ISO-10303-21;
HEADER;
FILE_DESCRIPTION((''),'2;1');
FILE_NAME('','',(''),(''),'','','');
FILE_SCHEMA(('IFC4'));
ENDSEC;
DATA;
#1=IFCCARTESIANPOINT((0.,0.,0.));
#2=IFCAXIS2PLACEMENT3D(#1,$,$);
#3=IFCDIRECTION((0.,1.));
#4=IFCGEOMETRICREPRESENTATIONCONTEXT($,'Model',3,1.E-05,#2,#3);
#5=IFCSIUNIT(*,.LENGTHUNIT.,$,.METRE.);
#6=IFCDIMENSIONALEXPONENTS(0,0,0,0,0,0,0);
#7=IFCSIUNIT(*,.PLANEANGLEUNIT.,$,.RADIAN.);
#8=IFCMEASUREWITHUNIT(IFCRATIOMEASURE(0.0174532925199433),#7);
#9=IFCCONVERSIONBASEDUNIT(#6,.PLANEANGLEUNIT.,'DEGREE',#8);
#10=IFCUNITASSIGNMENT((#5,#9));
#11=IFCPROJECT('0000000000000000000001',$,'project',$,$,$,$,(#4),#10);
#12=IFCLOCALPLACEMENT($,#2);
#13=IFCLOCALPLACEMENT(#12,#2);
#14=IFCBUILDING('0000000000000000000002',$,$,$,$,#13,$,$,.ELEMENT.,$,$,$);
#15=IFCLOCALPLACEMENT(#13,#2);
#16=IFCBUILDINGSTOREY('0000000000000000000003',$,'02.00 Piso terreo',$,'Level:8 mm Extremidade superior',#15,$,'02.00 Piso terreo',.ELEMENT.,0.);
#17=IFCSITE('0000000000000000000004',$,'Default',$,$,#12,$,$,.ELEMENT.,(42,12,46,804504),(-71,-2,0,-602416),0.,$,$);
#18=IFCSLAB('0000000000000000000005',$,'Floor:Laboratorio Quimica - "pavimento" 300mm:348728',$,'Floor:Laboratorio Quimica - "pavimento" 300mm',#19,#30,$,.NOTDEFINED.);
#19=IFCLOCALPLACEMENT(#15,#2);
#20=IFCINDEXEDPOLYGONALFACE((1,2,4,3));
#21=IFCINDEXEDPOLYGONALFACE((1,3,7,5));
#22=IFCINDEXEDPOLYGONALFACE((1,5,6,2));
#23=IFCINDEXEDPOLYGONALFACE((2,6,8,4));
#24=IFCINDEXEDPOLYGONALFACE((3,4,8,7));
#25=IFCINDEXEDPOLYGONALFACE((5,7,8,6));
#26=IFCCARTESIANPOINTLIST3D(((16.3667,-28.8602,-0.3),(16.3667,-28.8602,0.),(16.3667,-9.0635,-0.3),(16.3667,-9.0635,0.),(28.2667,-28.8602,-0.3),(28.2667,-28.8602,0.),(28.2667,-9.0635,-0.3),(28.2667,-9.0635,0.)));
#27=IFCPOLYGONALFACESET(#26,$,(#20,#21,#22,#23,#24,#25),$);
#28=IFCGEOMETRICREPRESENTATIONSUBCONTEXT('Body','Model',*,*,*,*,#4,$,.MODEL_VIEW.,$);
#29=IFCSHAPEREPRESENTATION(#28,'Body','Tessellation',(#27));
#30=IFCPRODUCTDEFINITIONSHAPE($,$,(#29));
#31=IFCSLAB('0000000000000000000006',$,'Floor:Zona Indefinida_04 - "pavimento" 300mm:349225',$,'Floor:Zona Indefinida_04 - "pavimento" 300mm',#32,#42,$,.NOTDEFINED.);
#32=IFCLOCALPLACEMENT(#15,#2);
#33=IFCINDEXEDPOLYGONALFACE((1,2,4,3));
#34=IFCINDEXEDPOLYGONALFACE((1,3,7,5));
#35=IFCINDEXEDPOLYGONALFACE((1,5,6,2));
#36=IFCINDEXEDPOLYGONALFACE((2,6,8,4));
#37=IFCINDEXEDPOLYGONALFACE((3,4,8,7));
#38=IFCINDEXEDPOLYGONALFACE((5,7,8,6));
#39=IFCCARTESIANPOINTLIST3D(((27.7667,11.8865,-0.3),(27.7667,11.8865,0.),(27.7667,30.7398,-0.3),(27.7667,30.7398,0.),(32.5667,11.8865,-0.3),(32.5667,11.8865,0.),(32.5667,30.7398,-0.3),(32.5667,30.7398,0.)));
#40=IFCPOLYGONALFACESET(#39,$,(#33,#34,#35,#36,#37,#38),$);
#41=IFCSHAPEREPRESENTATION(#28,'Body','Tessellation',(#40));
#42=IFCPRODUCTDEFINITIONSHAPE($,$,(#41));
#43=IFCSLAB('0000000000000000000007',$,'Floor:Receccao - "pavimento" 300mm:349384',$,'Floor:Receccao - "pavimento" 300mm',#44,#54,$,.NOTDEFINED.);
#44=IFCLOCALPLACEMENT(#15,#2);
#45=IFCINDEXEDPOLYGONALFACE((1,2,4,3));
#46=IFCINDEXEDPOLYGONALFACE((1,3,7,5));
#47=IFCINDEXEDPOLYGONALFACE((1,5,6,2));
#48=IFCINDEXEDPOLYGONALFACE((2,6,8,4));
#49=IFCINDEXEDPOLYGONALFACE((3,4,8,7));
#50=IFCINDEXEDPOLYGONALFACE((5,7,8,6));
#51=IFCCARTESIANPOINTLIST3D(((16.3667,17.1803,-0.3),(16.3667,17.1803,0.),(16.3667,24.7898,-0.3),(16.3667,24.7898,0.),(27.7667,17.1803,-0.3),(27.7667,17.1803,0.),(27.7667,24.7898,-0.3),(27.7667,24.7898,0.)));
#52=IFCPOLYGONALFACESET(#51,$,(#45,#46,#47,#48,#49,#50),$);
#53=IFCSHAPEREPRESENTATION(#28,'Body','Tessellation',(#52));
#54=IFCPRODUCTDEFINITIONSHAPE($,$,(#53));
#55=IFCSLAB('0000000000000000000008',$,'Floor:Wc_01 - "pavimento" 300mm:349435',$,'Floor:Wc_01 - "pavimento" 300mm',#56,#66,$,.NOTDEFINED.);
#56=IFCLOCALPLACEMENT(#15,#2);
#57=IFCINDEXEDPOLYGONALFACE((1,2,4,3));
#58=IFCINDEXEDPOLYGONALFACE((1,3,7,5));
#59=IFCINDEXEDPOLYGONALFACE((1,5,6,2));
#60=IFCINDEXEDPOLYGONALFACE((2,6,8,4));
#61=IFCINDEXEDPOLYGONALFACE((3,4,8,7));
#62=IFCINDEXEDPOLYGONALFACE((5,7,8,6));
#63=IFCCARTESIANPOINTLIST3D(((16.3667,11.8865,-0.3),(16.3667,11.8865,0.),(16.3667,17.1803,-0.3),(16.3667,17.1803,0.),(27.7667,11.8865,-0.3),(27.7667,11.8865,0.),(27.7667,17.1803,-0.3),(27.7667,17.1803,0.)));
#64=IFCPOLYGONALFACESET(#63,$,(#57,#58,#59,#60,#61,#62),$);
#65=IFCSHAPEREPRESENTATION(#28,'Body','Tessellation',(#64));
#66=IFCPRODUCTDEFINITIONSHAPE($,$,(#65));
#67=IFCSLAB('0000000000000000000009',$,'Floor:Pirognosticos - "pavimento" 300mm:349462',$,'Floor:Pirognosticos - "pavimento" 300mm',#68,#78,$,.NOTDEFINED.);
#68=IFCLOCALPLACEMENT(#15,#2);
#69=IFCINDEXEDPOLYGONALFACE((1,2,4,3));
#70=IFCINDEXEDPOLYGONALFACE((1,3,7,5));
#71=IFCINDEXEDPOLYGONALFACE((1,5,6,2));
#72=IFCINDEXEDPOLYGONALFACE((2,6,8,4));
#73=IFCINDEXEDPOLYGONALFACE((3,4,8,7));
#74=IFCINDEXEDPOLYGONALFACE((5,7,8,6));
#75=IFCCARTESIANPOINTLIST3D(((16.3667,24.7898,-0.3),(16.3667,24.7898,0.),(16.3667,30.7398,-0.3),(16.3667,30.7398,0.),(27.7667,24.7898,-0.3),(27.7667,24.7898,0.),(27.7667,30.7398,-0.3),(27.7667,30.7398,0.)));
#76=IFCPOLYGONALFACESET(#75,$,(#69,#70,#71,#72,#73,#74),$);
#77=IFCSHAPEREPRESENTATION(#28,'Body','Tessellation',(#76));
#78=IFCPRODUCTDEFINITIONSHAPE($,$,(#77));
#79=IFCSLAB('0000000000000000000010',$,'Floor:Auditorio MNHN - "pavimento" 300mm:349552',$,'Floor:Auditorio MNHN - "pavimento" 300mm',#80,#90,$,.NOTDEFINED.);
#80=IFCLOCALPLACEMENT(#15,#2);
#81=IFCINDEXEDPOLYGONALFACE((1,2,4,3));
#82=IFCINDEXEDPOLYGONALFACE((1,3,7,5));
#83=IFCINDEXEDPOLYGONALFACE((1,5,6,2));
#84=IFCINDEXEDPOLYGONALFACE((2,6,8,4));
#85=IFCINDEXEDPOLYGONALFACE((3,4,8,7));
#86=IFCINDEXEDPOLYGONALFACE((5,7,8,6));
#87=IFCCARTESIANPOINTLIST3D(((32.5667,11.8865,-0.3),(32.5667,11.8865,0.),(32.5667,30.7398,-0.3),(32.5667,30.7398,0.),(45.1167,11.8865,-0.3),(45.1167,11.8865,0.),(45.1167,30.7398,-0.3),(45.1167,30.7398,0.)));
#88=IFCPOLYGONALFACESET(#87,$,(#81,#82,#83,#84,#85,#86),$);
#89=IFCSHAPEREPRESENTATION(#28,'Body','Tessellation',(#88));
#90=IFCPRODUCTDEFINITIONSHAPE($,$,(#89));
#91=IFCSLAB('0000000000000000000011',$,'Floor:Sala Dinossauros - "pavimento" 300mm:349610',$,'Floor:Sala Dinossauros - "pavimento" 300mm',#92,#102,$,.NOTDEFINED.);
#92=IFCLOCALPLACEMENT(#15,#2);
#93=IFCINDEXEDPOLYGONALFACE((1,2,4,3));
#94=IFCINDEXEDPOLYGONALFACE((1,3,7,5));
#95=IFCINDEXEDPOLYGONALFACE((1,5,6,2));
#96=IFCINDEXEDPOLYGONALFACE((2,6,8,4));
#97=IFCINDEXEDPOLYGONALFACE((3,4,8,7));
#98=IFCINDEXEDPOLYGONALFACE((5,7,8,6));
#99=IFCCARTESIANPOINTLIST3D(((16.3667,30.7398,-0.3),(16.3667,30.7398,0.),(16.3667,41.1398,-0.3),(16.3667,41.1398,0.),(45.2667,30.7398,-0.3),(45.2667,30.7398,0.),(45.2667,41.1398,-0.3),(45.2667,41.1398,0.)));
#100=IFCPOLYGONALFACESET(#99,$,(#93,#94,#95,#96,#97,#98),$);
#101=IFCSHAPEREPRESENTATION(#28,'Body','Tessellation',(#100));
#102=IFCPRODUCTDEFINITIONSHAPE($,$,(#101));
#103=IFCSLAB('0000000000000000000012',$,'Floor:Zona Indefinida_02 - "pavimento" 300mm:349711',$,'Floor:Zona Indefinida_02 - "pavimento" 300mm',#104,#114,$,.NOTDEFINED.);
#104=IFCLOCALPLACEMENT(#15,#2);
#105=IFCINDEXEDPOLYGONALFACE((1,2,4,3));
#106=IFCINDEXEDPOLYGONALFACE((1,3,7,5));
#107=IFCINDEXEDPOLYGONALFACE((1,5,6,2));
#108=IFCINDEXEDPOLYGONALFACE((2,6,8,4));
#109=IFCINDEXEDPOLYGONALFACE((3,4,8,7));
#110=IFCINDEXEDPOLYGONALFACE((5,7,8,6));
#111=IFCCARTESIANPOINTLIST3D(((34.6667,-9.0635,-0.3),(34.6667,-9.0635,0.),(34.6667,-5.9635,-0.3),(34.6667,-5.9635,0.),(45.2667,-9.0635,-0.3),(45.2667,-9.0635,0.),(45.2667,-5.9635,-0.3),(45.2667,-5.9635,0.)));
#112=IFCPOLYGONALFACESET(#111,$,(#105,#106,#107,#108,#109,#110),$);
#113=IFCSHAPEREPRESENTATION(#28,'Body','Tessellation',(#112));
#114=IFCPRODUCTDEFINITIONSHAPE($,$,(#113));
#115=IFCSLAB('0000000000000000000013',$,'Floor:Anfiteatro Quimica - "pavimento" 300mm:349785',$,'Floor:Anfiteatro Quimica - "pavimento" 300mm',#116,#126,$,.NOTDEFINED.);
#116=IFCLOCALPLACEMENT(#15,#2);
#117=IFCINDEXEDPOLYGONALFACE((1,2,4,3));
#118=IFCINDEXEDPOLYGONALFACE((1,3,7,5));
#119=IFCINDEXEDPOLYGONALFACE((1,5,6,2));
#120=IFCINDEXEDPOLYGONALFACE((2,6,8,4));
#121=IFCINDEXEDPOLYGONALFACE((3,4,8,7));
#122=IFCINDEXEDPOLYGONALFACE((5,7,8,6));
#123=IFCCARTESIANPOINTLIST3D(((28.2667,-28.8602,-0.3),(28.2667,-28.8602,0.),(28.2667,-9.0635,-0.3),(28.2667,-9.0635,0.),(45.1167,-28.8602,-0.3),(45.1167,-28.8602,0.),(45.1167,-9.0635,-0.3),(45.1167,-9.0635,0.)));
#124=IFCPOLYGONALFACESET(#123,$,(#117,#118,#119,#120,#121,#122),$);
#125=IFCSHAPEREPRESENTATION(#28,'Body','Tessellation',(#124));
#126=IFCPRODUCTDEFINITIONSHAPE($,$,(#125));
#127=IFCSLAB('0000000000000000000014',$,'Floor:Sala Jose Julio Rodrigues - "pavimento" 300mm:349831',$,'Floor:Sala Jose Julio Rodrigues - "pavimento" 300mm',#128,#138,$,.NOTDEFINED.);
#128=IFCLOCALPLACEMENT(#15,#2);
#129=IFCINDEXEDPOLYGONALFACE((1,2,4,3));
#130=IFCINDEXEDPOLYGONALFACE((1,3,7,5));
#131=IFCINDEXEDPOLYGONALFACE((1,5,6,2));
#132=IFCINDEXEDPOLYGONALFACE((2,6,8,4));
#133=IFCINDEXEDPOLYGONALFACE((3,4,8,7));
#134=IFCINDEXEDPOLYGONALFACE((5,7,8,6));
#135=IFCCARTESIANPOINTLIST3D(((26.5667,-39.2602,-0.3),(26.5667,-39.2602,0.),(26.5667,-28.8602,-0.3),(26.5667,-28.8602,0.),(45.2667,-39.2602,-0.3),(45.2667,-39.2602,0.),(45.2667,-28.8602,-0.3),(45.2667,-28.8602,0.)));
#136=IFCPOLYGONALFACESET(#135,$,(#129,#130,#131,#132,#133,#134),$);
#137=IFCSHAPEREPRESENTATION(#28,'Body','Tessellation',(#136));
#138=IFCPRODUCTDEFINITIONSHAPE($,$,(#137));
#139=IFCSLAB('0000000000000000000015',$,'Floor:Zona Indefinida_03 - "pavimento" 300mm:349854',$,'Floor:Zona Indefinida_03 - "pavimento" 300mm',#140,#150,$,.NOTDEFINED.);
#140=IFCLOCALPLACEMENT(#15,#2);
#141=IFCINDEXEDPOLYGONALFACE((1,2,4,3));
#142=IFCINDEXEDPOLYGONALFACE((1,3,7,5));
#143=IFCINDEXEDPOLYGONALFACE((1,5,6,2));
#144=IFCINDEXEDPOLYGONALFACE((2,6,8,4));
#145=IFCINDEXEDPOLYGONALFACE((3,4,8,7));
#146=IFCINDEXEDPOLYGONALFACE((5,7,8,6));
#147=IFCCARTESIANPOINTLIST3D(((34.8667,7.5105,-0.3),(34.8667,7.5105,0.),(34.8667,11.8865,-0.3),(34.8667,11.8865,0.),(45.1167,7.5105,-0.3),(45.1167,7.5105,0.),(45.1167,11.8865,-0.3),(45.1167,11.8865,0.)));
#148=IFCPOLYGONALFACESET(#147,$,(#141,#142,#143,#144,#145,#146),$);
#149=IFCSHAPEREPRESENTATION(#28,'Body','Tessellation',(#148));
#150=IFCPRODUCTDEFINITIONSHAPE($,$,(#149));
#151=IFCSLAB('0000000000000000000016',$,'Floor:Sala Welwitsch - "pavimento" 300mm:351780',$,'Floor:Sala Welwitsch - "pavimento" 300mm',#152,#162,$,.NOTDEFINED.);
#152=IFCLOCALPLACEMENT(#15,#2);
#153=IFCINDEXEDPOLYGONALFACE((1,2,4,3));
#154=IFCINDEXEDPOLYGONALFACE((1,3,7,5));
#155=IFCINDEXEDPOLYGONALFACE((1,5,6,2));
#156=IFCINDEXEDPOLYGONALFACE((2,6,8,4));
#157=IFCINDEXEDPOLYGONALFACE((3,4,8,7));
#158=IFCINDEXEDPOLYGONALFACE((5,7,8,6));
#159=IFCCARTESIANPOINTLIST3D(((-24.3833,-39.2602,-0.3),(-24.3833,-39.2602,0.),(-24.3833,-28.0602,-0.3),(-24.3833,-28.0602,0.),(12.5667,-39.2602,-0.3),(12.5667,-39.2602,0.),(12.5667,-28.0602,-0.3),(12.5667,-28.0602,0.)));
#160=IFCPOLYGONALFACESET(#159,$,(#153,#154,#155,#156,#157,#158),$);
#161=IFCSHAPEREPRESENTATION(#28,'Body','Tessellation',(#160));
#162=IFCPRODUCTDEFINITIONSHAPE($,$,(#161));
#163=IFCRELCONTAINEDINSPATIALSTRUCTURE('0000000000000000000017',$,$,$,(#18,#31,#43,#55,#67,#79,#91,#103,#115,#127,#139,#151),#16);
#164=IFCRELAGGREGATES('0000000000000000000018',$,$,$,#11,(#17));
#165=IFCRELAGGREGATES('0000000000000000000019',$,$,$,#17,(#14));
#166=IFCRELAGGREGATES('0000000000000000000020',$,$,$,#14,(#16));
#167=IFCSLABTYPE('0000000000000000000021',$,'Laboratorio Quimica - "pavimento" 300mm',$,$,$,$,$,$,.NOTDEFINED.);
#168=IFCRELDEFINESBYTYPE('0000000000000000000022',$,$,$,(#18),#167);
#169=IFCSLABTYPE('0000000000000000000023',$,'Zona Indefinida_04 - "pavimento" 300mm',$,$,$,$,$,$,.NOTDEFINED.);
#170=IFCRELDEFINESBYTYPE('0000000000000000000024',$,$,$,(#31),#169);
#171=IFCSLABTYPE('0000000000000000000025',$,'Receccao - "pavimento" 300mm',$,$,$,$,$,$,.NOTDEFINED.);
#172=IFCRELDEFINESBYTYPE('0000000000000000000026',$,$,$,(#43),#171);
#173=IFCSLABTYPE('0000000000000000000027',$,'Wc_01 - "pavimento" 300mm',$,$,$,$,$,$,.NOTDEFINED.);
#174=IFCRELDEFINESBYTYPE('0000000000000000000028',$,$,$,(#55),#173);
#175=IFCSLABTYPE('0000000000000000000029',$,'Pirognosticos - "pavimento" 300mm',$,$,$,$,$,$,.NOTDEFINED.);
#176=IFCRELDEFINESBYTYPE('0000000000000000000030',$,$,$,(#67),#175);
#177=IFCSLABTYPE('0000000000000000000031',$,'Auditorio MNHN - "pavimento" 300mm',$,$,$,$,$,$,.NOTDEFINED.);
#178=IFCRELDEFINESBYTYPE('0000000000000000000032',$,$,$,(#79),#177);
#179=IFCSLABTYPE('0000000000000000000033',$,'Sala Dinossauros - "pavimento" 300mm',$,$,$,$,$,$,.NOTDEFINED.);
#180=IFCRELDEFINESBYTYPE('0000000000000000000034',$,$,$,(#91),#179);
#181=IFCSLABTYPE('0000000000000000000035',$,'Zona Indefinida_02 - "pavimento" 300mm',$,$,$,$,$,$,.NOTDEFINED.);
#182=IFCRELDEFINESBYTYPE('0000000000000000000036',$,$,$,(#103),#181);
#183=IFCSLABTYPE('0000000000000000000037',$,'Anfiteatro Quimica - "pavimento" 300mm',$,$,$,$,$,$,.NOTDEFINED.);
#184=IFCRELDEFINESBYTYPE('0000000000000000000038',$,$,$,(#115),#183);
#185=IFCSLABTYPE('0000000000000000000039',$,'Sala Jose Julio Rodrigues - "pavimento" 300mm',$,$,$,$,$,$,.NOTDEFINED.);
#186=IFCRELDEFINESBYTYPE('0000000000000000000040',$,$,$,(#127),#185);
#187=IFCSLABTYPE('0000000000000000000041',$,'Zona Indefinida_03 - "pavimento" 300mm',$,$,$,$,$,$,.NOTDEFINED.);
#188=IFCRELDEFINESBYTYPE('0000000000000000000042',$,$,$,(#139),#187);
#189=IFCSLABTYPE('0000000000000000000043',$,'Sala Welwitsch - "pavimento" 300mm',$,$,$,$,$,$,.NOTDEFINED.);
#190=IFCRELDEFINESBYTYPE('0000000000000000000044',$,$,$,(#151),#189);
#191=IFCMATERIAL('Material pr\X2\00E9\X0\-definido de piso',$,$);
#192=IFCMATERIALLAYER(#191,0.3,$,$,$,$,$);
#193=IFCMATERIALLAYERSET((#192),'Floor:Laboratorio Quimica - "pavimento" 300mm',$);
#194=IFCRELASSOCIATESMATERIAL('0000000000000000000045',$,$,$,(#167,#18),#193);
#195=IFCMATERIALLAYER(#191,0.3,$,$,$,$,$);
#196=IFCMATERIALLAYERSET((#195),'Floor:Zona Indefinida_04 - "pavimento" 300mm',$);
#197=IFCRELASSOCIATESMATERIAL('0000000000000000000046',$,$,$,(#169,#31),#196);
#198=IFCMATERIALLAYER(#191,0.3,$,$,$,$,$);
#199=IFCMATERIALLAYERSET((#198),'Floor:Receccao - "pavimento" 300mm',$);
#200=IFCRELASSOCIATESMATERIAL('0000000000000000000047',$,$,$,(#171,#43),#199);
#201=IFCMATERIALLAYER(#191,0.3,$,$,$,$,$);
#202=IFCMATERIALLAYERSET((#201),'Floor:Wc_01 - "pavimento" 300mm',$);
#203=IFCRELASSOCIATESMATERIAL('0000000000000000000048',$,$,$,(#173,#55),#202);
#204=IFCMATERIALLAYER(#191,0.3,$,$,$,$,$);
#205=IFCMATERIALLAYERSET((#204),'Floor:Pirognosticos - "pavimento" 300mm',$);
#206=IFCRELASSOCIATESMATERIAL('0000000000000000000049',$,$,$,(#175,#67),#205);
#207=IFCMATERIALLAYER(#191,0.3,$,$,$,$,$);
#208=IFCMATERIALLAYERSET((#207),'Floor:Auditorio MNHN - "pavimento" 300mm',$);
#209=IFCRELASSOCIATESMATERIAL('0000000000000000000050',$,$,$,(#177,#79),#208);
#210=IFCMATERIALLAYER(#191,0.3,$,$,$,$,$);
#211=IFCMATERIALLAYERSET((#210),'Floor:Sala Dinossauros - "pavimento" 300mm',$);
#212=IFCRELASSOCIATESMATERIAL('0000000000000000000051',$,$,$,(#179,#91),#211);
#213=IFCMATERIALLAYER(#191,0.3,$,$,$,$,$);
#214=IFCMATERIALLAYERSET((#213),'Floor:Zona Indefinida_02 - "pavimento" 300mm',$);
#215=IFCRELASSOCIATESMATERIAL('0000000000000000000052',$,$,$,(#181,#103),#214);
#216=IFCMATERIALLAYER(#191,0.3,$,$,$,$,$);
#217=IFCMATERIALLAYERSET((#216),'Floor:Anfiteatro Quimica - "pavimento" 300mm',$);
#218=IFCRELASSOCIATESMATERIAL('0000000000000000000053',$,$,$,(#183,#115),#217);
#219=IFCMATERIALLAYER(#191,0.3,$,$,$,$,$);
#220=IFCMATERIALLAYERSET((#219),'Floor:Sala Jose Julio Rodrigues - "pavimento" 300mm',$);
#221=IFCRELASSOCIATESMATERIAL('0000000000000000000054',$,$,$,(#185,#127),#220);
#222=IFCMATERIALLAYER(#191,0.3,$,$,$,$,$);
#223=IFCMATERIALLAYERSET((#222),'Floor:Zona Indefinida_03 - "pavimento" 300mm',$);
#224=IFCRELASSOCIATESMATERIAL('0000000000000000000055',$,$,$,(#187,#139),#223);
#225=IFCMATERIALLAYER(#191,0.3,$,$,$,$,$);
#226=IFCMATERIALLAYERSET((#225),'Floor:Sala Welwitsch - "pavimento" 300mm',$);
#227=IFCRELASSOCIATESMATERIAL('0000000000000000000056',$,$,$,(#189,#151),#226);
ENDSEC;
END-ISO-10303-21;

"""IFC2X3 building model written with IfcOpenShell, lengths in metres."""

from ifc_helpers import new_model, entity, si_unit, converted_unit, direction, frame, frame_2d, origin, origin_2d_with_axis, place, context, subcontext, project, spatial, rectangle, extrude, material, layer, layer_set, layer_usage, type_object, element, save


model = new_model("IFC2X3")

# Units and contexts
model_context = context("Model", 3, precision=1e-05, world=origin(), true_north=direction((0.0, 1.0)))
body_context = subcontext(model_context, "Body", "Model", "MODEL_VIEW")
ifc_project = project(units=[si_unit("LENGTHUNIT", "METRE"), converted_unit("PLANEANGLEUNIT", "DEGREE", entity("IfcRatioMeasure", 0.0174532925199433), si_unit("PLANEANGLEUNIT", "RADIAN"), dimensions=[0, 0, 0, 0, 0, 0, 0])], contexts=[model_context])

# Site, building, storey
site_placement = place(None, origin())
site = spatial("IfcSite", under=ifc_project, at=site_placement, Name="Default", CompositionType="ELEMENT", RefLatitude=(42, 12, 46, 804504), RefLongitude=(-71, -2, 0, -602416), RefElevation=0.0)
building_placement = place(site_placement, origin())
building = spatial("IfcBuilding", under=site, at=building_placement, CompositionType="ELEMENT")
storey_placement = place(building_placement, origin())
storey = spatial("IfcBuildingStorey", under=building, at=storey_placement, Name="02.00 Piso terreo", ObjectType="Level:8 mm Extremidade superior", LongName="02.00 Piso terreo", CompositionType="ELEMENT", Elevation=0.0)

# Slabs
ifc_material = material(Name="Material pré-definido de piso")
ifc_layer_1 = layer(ifc_material, 0.3)
ifc_layer_set_1 = layer_set([ifc_layer_1], Name="Floor:Laboratorio Quimica - \"pavimento\" 300mm")
ifc_layer_usage_1 = layer_usage(ifc_layer_set_1, "AXIS3", "POSITIVE", 0.0)
slab_type_1 = type_object("IfcSlabType", Name="Laboratorio Quimica - \"pavimento\" 300mm", PredefinedType="NOTDEFINED", material=ifc_layer_set_1)
slab_1_placement = place(storey_placement, origin())
element("IfcSlab", 1, at=slab_1_placement, inside=storey, type_object=slab_type_1, material=ifc_layer_usage_1, Name="Floor:Laboratorio Quimica - \"pavimento\" 300mm:348728", ObjectType="Floor:Laboratorio Quimica - \"pavimento\" 300mm", PredefinedType="NOTDEFINED", context=body_context, shape_type="SweptSolid", body=[
    extrude(rectangle(XDim=19.7967, YDim=11.9, at=frame_2d((0.0, 0.0), x_axis=(1.0, 0.0))), frame((22.3167, -18.9618, 0.0), z_axis=(0.0, 0.0, -1.0), x_axis=(0.0, 1.0, 0.0)), (0.0, 0.0, 1.0), 0.3),
])
ifc_layer_2 = layer(ifc_material, 0.3)
ifc_layer_set_2 = layer_set([ifc_layer_2], Name="Floor:Zona Indefinida_04 - \"pavimento\" 300mm")
ifc_layer_usage_2 = layer_usage(ifc_layer_set_2, "AXIS3", "POSITIVE", 0.0)
slab_type_2 = type_object("IfcSlabType", Name="Zona Indefinida_04 - \"pavimento\" 300mm", PredefinedType="NOTDEFINED", material=ifc_layer_set_2)
slab_2_placement = place(storey_placement, origin())
element("IfcSlab", 2, at=slab_2_placement, inside=storey, type_object=slab_type_2, material=ifc_layer_usage_2, Name="Floor:Zona Indefinida_04 - \"pavimento\" 300mm:349225", ObjectType="Floor:Zona Indefinida_04 - \"pavimento\" 300mm", PredefinedType="NOTDEFINED", context=body_context, shape_type="SweptSolid", body=[
    extrude(rectangle(XDim=18.8533, YDim=4.8, at=frame_2d((0.0, 0.0), x_axis=(1.0, 0.0))), frame((30.1667, 21.3132, 0.0), z_axis=(0.0, 0.0, -1.0), x_axis=(0.0, 1.0, 0.0)), (0.0, 0.0, 1.0), 0.3),
])
ifc_layer_3 = layer(ifc_material, 0.3)
ifc_layer_set_3 = layer_set([ifc_layer_3], Name="Floor:Receccao - \"pavimento\" 300mm")
ifc_layer_usage_3 = layer_usage(ifc_layer_set_3, "AXIS3", "POSITIVE", 0.0)
slab_type_3 = type_object("IfcSlabType", Name="Receccao - \"pavimento\" 300mm", PredefinedType="NOTDEFINED", material=ifc_layer_set_3)
slab_3_placement = place(storey_placement, origin())
element("IfcSlab", 3, at=slab_3_placement, inside=storey, type_object=slab_type_3, material=ifc_layer_usage_3, Name="Floor:Receccao - \"pavimento\" 300mm:349384", ObjectType="Floor:Receccao - \"pavimento\" 300mm", PredefinedType="NOTDEFINED", context=body_context, shape_type="SweptSolid", body=[
    extrude(rectangle(XDim=7.6095, YDim=11.4, at=frame_2d((0.0, 0.0), x_axis=(1.0, 0.0))), frame((22.0667, 20.9851, 0.0), z_axis=(0.0, 0.0, -1.0), x_axis=(0.0, 1.0, 0.0)), (0.0, 0.0, 1.0), 0.3),
])
ifc_layer_4 = layer(ifc_material, 0.3)
ifc_layer_set_4 = layer_set([ifc_layer_4], Name="Floor:Wc_01 - \"pavimento\" 300mm")
ifc_layer_usage_4 = layer_usage(ifc_layer_set_4, "AXIS3", "POSITIVE", 0.0)
slab_type_4 = type_object("IfcSlabType", Name="Wc_01 - \"pavimento\" 300mm", PredefinedType="NOTDEFINED", material=ifc_layer_set_4)
slab_4_placement = place(storey_placement, origin())
element("IfcSlab", 4, at=slab_4_placement, inside=storey, type_object=slab_type_4, material=ifc_layer_usage_4, Name="Floor:Wc_01 - \"pavimento\" 300mm:349435", ObjectType="Floor:Wc_01 - \"pavimento\" 300mm", PredefinedType="NOTDEFINED", context=body_context, shape_type="SweptSolid", body=[
    extrude(rectangle(XDim=5.2938, YDim=11.4, at=frame_2d((0.0, 0.0), x_axis=(1.0, 0.0))), frame((22.0667, 14.5334, 0.0), z_axis=(0.0, 0.0, -1.0), x_axis=(0.0, 1.0, 0.0)), (0.0, 0.0, 1.0), 0.3),
])
ifc_layer_5 = layer(ifc_material, 0.3)
ifc_layer_set_5 = layer_set([ifc_layer_5], Name="Floor:Pirognosticos - \"pavimento\" 300mm")
ifc_layer_usage_5 = layer_usage(ifc_layer_set_5, "AXIS3", "POSITIVE", 0.0)
slab_type_5 = type_object("IfcSlabType", Name="Pirognosticos - \"pavimento\" 300mm", PredefinedType="NOTDEFINED", material=ifc_layer_set_5)
slab_5_placement = place(storey_placement, origin())
element("IfcSlab", 5, at=slab_5_placement, inside=storey, type_object=slab_type_5, material=ifc_layer_usage_5, Name="Floor:Pirognosticos - \"pavimento\" 300mm:349462", ObjectType="Floor:Pirognosticos - \"pavimento\" 300mm", PredefinedType="NOTDEFINED", context=body_context, shape_type="SweptSolid", body=[
    extrude(rectangle(XDim=5.95, YDim=11.4, at=origin_2d_with_axis()), frame((22.0667, 27.7648, 0.0), z_axis=(0.0, 0.0, -1.0), x_axis=(0.0, 1.0, 0.0)), (0.0, 0.0, 1.0), 0.3),
])
ifc_layer_6 = layer(ifc_material, 0.3)
ifc_layer_set_6 = layer_set([ifc_layer_6], Name="Floor:Auditorio MNHN - \"pavimento\" 300mm")
ifc_layer_usage_6 = layer_usage(ifc_layer_set_6, "AXIS3", "POSITIVE", 0.0)
slab_type_6 = type_object("IfcSlabType", Name="Auditorio MNHN - \"pavimento\" 300mm", PredefinedType="NOTDEFINED", material=ifc_layer_set_6)
slab_6_placement = place(storey_placement, origin())
element("IfcSlab", 6, at=slab_6_placement, inside=storey, type_object=slab_type_6, material=ifc_layer_usage_6, Name="Floor:Auditorio MNHN - \"pavimento\" 300mm:349552", ObjectType="Floor:Auditorio MNHN - \"pavimento\" 300mm", PredefinedType="NOTDEFINED", context=body_context, shape_type="SweptSolid", body=[
    extrude(rectangle(XDim=18.8533, YDim=12.55, at=frame_2d((0.0, 0.0), x_axis=(1.0, 0.0))), frame((38.8417, 21.3132, 0.0), z_axis=(0.0, 0.0, -1.0), x_axis=(0.0, 1.0, 0.0)), (0.0, 0.0, 1.0), 0.3),
])
ifc_layer_7 = layer(ifc_material, 0.3)
ifc_layer_set_7 = layer_set([ifc_layer_7], Name="Floor:Sala Dinossauros - \"pavimento\" 300mm")
ifc_layer_usage_7 = layer_usage(ifc_layer_set_7, "AXIS3", "POSITIVE", 0.0)
slab_type_7 = type_object("IfcSlabType", Name="Sala Dinossauros - \"pavimento\" 300mm", PredefinedType="NOTDEFINED", material=ifc_layer_set_7)
slab_7_placement = place(storey_placement, origin())
element("IfcSlab", 7, at=slab_7_placement, inside=storey, type_object=slab_type_7, material=ifc_layer_usage_7, Name="Floor:Sala Dinossauros - \"pavimento\" 300mm:349610", ObjectType="Floor:Sala Dinossauros - \"pavimento\" 300mm", PredefinedType="NOTDEFINED", context=body_context, shape_type="SweptSolid", body=[
    extrude(rectangle(XDim=10.4, YDim=28.9, at=frame_2d((0.0, 0.0), x_axis=(1.0, 0.0))), frame((30.8167, 35.9398, 0.0), z_axis=(0.0, 0.0, -1.0), x_axis=(0.0, 1.0, 0.0)), (0.0, 0.0, 1.0), 0.3),
])
ifc_layer_8 = layer(ifc_material, 0.3)
ifc_layer_set_8 = layer_set([ifc_layer_8], Name="Floor:Zona Indefinida_02 - \"pavimento\" 300mm")
ifc_layer_usage_8 = layer_usage(ifc_layer_set_8, "AXIS3", "POSITIVE", 0.0)
slab_type_8 = type_object("IfcSlabType", Name="Zona Indefinida_02 - \"pavimento\" 300mm", PredefinedType="NOTDEFINED", material=ifc_layer_set_8)
slab_8_placement = place(storey_placement, origin())
element("IfcSlab", 8, at=slab_8_placement, inside=storey, type_object=slab_type_8, material=ifc_layer_usage_8, Name="Floor:Zona Indefinida_02 - \"pavimento\" 300mm:349711", ObjectType="Floor:Zona Indefinida_02 - \"pavimento\" 300mm", PredefinedType="NOTDEFINED", context=body_context, shape_type="SweptSolid", body=[
    extrude(rectangle(XDim=3.1, YDim=10.6, at=frame_2d((0.0, 0.0), x_axis=(1.0, 0.0))), frame((39.9667, -7.5135, 0.0), z_axis=(0.0, 0.0, -1.0), x_axis=(0.0, 1.0, 0.0)), (0.0, 0.0, 1.0), 0.3),
])
ifc_layer_9 = layer(ifc_material, 0.3)
ifc_layer_set_9 = layer_set([ifc_layer_9], Name="Floor:Anfiteatro Quimica - \"pavimento\" 300mm")
ifc_layer_usage_9 = layer_usage(ifc_layer_set_9, "AXIS3", "POSITIVE", 0.0)
slab_type_9 = type_object("IfcSlabType", Name="Anfiteatro Quimica - \"pavimento\" 300mm", PredefinedType="NOTDEFINED", material=ifc_layer_set_9)
slab_9_placement = place(storey_placement, origin())
element("IfcSlab", 9, at=slab_9_placement, inside=storey, type_object=slab_type_9, material=ifc_layer_usage_9, Name="Floor:Anfiteatro Quimica - \"pavimento\" 300mm:349785", ObjectType="Floor:Anfiteatro Quimica - \"pavimento\" 300mm", PredefinedType="NOTDEFINED", context=body_context, shape_type="SweptSolid", body=[
    extrude(rectangle(XDim=19.7967, YDim=16.85, at=frame_2d((0.0, 0.0), x_axis=(1.0, 0.0))), frame((36.6917, -18.9618, 0.0), z_axis=(0.0, 0.0, -1.0), x_axis=(0.0, 1.0, 0.0)), (0.0, 0.0, 1.0), 0.3),
])
ifc_layer_10 = layer(ifc_material, 0.3)
ifc_layer_set_10 = layer_set([ifc_layer_10], Name="Floor:Sala Jose Julio Rodrigues - \"pavimento\" 300mm")
ifc_layer_usage_10 = layer_usage(ifc_layer_set_10, "AXIS3", "POSITIVE", 0.0)
slab_type_10 = type_object("IfcSlabType", Name="Sala Jose Julio Rodrigues - \"pavimento\" 300mm", PredefinedType="NOTDEFINED", material=ifc_layer_set_10)
slab_10_placement = place(storey_placement, origin())
element("IfcSlab", 10, at=slab_10_placement, inside=storey, type_object=slab_type_10, material=ifc_layer_usage_10, Name="Floor:Sala Jose Julio Rodrigues - \"pavimento\" 300mm:349831", ObjectType="Floor:Sala Jose Julio Rodrigues - \"pavimento\" 300mm", PredefinedType="NOTDEFINED", context=body_context, shape_type="SweptSolid", body=[
    extrude(rectangle(XDim=10.4, YDim=18.7, at=frame_2d((0.0, 0.0), x_axis=(1.0, 0.0))), frame((35.9167, -34.0602, 0.0), z_axis=(0.0, 0.0, -1.0), x_axis=(0.0, 1.0, 0.0)), (0.0, 0.0, 1.0), 0.3),
])
ifc_layer_11 = layer(ifc_material, 0.3)
ifc_layer_set_11 = layer_set([ifc_layer_11], Name="Floor:Zona Indefinida_03 - \"pavimento\" 300mm")
ifc_layer_usage_11 = layer_usage(ifc_layer_set_11, "AXIS3", "POSITIVE", 0.0)
slab_type_11 = type_object("IfcSlabType", Name="Zona Indefinida_03 - \"pavimento\" 300mm", PredefinedType="NOTDEFINED", material=ifc_layer_set_11)
slab_11_placement = place(storey_placement, origin())
element("IfcSlab", 11, at=slab_11_placement, inside=storey, type_object=slab_type_11, material=ifc_layer_usage_11, Name="Floor:Zona Indefinida_03 - \"pavimento\" 300mm:349854", ObjectType="Floor:Zona Indefinida_03 - \"pavimento\" 300mm", PredefinedType="NOTDEFINED", context=body_context, shape_type="SweptSolid", body=[
    extrude(rectangle(XDim=4.376, YDim=10.25, at=frame_2d((0.0, 0.0), x_axis=(1.0, 0.0))), frame((39.9917, 9.6985, 0.0), z_axis=(0.0, 0.0, -1.0), x_axis=(0.0, 1.0, 0.0)), (0.0, 0.0, 1.0), 0.3),
])
ifc_layer_12 = layer(ifc_material, 0.3)
ifc_layer_set_12 = layer_set([ifc_layer_12], Name="Floor:Sala Welwitsch - \"pavimento\" 300mm")
ifc_layer_usage_12 = layer_usage(ifc_layer_set_12, "AXIS3", "POSITIVE", 0.0)
slab_type_12 = type_object("IfcSlabType", Name="Sala Welwitsch - \"pavimento\" 300mm", PredefinedType="NOTDEFINED", material=ifc_layer_set_12)
slab_12_placement = place(storey_placement, origin())
element("IfcSlab", 12, at=slab_12_placement, inside=storey, type_object=slab_type_12, material=ifc_layer_usage_12, Name="Floor:Sala Welwitsch - \"pavimento\" 300mm:351780", ObjectType="Floor:Sala Welwitsch - \"pavimento\" 300mm", PredefinedType="NOTDEFINED", context=body_context, shape_type="SweptSolid", body=[
    extrude(rectangle(XDim=11.2, YDim=36.95, at=origin_2d_with_axis()), frame((-5.9083, -33.6602, 0.0), z_axis=(0.0, 0.0, -1.0), x_axis=(0.0, 1.0, 0.0)), (0.0, 0.0, 1.0), 0.3),
])

save(model, "model.ifc")
